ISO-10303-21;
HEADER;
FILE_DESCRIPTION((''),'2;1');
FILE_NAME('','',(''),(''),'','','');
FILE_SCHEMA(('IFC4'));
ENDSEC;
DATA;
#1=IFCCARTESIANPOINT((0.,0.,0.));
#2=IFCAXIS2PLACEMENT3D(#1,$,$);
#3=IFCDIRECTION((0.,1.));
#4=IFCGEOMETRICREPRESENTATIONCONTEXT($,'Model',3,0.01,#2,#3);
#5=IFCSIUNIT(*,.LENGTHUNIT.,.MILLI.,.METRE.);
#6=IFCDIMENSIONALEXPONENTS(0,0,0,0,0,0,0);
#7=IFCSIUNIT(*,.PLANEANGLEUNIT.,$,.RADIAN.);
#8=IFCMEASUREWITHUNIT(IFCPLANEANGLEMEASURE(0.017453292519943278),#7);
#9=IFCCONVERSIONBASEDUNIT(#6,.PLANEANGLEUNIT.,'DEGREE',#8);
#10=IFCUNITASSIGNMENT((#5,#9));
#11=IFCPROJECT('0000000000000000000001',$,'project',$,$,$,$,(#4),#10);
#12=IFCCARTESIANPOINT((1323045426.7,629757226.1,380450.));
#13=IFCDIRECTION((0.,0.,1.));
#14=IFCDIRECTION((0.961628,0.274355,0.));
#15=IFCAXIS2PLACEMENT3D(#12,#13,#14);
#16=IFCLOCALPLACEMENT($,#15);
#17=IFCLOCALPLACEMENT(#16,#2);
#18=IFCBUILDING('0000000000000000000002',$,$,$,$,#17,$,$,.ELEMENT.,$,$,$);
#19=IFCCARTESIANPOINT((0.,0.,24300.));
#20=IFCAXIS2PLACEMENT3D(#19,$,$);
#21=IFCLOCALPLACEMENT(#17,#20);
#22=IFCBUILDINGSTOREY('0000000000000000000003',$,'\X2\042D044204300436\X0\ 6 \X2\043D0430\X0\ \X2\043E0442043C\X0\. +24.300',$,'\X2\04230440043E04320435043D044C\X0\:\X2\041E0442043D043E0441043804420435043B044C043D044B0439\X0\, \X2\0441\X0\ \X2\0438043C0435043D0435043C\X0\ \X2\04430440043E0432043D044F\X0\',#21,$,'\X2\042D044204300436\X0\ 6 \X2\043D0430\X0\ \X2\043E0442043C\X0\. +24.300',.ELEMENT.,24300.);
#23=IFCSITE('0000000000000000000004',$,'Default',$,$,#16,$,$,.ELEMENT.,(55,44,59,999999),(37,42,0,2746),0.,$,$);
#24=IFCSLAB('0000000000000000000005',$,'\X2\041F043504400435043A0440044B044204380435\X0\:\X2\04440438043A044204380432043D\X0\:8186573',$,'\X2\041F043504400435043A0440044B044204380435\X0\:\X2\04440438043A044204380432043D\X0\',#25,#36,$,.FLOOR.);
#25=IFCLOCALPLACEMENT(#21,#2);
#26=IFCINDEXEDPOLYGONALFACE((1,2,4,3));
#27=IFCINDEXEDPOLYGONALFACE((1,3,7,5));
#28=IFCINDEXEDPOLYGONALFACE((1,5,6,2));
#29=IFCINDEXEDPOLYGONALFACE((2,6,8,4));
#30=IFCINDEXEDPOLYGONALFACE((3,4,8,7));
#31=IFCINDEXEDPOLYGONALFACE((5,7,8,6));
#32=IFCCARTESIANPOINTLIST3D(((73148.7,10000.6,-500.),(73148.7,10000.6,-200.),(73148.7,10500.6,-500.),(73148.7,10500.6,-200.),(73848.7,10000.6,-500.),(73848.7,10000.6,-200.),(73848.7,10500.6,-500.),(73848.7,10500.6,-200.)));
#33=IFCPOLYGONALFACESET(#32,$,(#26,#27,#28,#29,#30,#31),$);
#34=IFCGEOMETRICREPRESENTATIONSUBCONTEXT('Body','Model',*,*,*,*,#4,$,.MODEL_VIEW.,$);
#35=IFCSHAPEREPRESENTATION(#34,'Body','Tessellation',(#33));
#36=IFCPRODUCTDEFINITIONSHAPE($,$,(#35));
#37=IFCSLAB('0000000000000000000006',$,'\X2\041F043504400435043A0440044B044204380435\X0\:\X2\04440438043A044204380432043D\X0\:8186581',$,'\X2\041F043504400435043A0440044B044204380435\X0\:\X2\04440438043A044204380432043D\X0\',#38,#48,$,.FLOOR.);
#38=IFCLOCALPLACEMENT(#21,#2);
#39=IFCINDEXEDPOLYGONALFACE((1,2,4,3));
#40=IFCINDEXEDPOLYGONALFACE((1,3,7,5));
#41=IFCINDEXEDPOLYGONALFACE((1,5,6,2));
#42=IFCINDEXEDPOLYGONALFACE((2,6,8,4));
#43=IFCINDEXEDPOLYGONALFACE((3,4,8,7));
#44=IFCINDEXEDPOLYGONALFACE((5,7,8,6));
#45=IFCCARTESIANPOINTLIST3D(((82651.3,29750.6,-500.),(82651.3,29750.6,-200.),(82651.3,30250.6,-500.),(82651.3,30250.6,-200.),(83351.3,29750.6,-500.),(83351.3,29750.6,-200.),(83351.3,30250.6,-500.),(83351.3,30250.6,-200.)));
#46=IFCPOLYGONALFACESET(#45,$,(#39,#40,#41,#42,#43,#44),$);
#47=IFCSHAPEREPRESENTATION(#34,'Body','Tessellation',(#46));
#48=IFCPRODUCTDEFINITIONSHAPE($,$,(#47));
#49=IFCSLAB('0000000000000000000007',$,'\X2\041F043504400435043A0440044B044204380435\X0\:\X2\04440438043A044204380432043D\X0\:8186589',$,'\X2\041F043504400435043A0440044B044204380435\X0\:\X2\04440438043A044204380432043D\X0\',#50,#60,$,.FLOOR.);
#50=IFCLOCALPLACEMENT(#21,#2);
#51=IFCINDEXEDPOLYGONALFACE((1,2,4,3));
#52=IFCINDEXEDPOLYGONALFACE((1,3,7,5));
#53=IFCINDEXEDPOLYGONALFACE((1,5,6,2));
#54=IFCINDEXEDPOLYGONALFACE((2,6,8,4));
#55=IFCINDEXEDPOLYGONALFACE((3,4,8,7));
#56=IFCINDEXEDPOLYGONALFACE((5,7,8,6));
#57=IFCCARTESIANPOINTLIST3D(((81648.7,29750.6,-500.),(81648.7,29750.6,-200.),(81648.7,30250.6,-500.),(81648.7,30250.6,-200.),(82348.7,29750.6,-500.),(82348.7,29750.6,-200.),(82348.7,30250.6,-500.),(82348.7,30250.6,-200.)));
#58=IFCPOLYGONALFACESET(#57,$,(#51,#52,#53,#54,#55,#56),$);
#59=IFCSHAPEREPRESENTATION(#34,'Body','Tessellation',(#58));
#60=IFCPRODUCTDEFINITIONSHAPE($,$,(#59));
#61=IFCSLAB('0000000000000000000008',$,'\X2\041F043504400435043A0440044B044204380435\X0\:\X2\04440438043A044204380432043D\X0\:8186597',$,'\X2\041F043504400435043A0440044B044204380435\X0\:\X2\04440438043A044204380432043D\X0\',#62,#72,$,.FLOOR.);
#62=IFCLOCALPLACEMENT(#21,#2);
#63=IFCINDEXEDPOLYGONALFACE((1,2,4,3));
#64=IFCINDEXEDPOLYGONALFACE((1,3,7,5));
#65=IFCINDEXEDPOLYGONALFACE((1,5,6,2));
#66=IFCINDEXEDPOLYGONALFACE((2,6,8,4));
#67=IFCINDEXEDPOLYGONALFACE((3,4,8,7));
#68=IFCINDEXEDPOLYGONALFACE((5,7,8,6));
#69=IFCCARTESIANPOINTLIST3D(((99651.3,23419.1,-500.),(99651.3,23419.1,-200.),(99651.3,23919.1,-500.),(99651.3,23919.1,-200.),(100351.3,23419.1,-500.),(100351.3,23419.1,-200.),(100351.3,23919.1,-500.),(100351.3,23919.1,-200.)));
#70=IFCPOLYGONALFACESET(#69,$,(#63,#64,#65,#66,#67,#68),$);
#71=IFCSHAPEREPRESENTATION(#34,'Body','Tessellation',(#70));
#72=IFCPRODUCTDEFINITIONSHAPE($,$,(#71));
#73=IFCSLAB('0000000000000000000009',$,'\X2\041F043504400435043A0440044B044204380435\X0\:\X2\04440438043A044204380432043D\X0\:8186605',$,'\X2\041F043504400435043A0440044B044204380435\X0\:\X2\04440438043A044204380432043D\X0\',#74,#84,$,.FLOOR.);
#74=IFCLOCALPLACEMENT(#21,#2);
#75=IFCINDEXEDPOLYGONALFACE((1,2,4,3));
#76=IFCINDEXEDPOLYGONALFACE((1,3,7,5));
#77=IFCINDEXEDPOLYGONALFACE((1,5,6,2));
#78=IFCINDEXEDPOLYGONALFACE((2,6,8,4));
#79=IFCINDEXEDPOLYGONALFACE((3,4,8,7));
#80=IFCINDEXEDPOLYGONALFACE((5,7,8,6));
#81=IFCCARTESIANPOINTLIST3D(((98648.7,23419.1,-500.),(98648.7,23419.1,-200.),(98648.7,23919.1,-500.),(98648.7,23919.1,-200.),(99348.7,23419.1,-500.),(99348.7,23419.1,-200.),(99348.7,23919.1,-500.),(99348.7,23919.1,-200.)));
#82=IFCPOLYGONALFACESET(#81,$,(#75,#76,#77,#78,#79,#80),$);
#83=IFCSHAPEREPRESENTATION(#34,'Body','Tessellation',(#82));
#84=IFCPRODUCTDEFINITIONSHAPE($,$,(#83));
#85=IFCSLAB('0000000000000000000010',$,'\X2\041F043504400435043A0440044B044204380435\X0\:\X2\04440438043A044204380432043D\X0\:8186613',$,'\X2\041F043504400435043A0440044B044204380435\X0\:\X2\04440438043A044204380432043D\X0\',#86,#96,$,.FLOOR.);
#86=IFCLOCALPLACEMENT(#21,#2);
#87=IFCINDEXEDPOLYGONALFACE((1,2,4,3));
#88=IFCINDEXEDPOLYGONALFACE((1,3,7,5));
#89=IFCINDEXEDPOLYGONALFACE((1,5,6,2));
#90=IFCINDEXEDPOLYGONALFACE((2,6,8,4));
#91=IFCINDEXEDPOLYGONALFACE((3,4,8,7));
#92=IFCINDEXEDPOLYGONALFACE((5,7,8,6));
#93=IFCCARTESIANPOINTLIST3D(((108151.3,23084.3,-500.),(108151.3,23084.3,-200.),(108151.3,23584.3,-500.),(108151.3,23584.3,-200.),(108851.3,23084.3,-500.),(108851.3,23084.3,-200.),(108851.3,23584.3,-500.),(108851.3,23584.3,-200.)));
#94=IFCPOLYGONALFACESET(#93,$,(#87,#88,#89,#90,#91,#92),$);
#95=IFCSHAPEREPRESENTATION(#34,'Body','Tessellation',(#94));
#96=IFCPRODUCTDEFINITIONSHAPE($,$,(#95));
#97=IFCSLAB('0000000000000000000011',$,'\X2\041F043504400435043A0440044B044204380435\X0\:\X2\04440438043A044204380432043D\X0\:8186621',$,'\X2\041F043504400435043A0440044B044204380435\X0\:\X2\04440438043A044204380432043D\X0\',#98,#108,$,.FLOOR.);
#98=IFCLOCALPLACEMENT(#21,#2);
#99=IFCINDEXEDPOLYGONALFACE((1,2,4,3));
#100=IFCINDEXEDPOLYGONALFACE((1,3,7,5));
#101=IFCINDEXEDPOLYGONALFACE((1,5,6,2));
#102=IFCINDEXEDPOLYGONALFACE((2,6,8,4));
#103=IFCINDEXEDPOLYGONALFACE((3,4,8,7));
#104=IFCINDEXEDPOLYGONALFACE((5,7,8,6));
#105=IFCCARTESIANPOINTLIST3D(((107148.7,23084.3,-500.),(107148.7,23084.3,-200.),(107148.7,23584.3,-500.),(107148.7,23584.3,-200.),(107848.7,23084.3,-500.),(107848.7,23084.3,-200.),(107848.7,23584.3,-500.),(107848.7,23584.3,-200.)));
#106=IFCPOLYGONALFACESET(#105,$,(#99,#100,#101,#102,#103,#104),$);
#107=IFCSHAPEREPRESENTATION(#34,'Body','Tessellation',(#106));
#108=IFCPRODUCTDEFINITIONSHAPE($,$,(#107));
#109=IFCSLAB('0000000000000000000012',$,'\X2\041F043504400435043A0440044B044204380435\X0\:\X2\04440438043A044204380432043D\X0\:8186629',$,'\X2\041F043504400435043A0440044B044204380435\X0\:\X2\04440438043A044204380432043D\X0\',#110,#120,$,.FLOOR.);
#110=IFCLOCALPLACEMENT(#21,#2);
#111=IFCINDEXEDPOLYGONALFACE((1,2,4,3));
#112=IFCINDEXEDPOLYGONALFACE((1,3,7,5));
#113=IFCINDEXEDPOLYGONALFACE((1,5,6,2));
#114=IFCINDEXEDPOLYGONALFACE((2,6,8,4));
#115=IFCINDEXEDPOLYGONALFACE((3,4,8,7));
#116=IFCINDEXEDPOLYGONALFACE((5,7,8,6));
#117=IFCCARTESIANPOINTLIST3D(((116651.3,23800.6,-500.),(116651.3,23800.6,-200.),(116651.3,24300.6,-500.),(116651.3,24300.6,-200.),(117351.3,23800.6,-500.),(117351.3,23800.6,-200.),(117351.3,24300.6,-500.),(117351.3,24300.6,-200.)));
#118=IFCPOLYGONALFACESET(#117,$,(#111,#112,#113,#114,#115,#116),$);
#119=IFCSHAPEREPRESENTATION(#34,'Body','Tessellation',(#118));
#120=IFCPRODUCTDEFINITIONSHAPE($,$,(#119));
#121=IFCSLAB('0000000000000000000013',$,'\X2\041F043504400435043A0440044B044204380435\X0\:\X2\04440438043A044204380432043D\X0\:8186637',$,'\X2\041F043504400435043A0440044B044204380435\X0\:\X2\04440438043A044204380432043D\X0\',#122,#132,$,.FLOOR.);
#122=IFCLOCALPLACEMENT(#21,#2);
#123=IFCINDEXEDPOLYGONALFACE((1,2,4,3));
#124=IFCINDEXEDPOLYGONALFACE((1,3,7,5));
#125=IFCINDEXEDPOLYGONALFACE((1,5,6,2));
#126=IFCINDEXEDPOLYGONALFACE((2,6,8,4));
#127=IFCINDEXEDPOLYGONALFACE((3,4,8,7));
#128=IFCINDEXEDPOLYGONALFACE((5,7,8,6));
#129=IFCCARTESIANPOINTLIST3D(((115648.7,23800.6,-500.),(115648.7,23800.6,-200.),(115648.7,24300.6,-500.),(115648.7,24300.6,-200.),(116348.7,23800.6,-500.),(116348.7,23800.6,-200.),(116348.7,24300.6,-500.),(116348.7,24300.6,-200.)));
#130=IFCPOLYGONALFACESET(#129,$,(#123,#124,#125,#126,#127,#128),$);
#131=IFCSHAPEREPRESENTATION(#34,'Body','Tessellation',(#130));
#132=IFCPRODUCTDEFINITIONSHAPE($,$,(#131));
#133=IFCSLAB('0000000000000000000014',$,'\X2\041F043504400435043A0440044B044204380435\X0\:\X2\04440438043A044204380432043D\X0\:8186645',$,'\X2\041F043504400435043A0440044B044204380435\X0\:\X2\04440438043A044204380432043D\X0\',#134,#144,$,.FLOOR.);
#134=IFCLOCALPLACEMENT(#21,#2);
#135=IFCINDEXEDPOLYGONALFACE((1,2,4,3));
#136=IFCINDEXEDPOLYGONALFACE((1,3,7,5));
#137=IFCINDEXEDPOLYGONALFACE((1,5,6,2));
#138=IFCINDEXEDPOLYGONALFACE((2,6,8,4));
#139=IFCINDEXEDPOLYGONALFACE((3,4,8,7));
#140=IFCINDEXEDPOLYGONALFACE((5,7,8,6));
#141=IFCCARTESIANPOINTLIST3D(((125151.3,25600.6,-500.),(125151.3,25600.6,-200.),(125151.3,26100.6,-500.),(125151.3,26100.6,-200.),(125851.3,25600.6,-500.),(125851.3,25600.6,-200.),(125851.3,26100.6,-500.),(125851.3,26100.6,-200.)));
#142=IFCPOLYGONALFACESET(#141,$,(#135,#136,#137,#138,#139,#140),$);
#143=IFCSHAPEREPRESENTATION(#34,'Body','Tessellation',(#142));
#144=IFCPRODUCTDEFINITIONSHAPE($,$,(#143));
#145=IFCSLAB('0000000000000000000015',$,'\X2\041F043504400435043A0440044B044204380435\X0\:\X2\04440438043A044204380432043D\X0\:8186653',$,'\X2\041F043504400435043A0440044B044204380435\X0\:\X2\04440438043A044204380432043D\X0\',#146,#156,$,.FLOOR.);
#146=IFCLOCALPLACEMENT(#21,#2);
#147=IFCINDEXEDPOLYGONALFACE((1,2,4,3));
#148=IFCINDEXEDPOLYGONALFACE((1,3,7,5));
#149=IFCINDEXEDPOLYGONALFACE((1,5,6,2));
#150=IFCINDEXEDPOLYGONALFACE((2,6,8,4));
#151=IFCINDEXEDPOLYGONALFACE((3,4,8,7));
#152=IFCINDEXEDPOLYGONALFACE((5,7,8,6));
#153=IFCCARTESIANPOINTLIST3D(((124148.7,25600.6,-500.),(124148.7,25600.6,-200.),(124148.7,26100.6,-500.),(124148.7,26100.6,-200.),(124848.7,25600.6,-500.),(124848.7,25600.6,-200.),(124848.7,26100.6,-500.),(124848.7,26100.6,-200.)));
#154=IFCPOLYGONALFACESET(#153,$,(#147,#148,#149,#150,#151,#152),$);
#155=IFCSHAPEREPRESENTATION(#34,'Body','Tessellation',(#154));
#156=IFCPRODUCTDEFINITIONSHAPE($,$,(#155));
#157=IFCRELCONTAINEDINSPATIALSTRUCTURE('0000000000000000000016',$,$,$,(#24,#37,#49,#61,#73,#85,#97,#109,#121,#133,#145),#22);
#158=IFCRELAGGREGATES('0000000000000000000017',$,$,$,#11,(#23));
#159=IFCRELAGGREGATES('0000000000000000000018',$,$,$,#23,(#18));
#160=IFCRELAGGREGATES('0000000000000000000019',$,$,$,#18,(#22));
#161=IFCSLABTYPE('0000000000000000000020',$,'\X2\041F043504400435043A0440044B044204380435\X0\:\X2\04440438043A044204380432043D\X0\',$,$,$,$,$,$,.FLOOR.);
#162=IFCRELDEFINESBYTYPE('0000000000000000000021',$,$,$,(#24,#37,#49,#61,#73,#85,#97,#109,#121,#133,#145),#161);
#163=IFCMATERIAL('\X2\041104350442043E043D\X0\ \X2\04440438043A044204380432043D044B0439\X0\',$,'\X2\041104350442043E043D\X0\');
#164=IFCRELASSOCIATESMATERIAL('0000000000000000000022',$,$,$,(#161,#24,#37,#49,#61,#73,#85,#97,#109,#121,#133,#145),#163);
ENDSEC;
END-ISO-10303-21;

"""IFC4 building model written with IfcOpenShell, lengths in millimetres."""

from ifc_helpers import new_model, entity, si_unit, converted_unit, direction, frame, origin, place, context, subcontext, project, spatial, indexed_curve, outline, extrude, material, type_object, element, save


model = new_model("IFC4")

# Units and contexts
model_context = context("Model", 3, precision=0.01, world=origin(), true_north=direction((0.0, 1.0)))
body_context = subcontext(model_context, "Body", "Model", "MODEL_VIEW")
ifc_project = project(units=[si_unit("LENGTHUNIT", "METRE", prefix="MILLI"), converted_unit("PLANEANGLEUNIT", "DEGREE", entity("IfcPlaneAngleMeasure", 0.017453292519943278), si_unit("PLANEANGLEUNIT", "RADIAN"), dimensions=[0, 0, 0, 0, 0, 0, 0])], contexts=[model_context])

# Site, building, storey
site_placement = place(None, frame((1323045426.7, 629757226.1, 380450.0), z_axis=(0.0, 0.0, 1.0), x_axis=(0.961628, 0.274355, 0.0)))
site = spatial("IfcSite", under=ifc_project, at=site_placement, Name="Default", CompositionType="ELEMENT", RefLatitude=(55, 44, 59, 999999), RefLongitude=(37, 42, 0, 2746), RefElevation=0.0)
building_placement = place(site_placement, origin())
building = spatial("IfcBuilding", under=site, at=building_placement, CompositionType="ELEMENT")
storey_placement = place(building_placement, frame((0.0, 0.0, 24300.0)))
storey = spatial("IfcBuildingStorey", under=building, at=storey_placement, Name="Этаж 6 на отм. +24.300", ObjectType="Уровень:Относительный, с именем уровня", LongName="Этаж 6 на отм. +24.300", CompositionType="ELEMENT", Elevation=24300.0)

# Slabs
ifc_material_1 = material(Name="Бетон фиктивный", Category="Бетон")
slab_type_1 = type_object("IfcSlabType", Name="Перекрытие:фиктивн", PredefinedType="FLOOR", material=ifc_material_1)
slab_1_placement = place(storey_placement, origin())
element("IfcSlab", 1, at=slab_1_placement, inside=storey, type_object=slab_type_1, material=ifc_material_1, Name="Перекрытие:фиктивн:8186573", ObjectType="Перекрытие:фиктивн", PredefinedType="FLOOR", context=body_context, shape_type="SweptSolid", body=[
    extrude(outline(indexed_curve([(-250.0, -350.0), (250.0, -350.0), (250.0, 350.0), (-250.0, 350.0), (-250.0, -350.0)], self_intersect=False)), frame((73498.7, 10250.6, -200.0), z_axis=(0.0, 0.0, -1.0), x_axis=(0.0, 1.0, 0.0)), (0.0, 0.0, 1.0), 300.0),
])
slab_2_placement = place(storey_placement, origin())
element("IfcSlab", 2, at=slab_2_placement, inside=storey, type_object=slab_type_1, material=ifc_material_1, Name="Перекрытие:фиктивн:8186581", ObjectType="Перекрытие:фиктивн", PredefinedType="FLOOR", context=body_context, shape_type="SweptSolid", body=[
    extrude(outline(indexed_curve([(-250.0, -350.0), (250.0, -350.0), (250.0, 350.0), (-250.0, 350.0), (-250.0, -350.0)], self_intersect=False)), frame((83001.3, 30000.6, -200.0), z_axis=(0.0, 0.0, -1.0), x_axis=(0.0, 1.0, 0.0)), (0.0, 0.0, 1.0), 300.0),
])
slab_3_placement = place(storey_placement, origin())
element("IfcSlab", 3, at=slab_3_placement, inside=storey, type_object=slab_type_1, material=ifc_material_1, Name="Перекрытие:фиктивн:8186589", ObjectType="Перекрытие:фиктивн", PredefinedType="FLOOR", context=body_context, shape_type="SweptSolid", body=[
    extrude(outline(indexed_curve([(-250.0, -350.0), (250.0, -350.0), (250.0, 350.0), (-250.0, 350.0), (-250.0, -350.0)], self_intersect=False)), frame((81998.7, 30000.6, -200.0), z_axis=(0.0, 0.0, -1.0), x_axis=(0.0, 1.0, 0.0)), (0.0, 0.0, 1.0), 300.0),
])
slab_4_placement = place(storey_placement, origin())
element("IfcSlab", 4, at=slab_4_placement, inside=storey, type_object=slab_type_1, material=ifc_material_1, Name="Перекрытие:фиктивн:8186597", ObjectType="Перекрытие:фиктивн", PredefinedType="FLOOR", context=body_context, shape_type="SweptSolid", body=[
    extrude(outline(indexed_curve([(-250.0, -350.0), (250.0, -350.0), (250.0, 350.0), (-250.0, 350.0), (-250.0, -350.0)], self_intersect=False)), frame((100001.3, 23669.1, -200.0), z_axis=(0.0, 0.0, -1.0), x_axis=(0.0, 1.0, 0.0)), (0.0, 0.0, 1.0), 300.0),
])
slab_5_placement = place(storey_placement, origin())
element("IfcSlab", 5, at=slab_5_placement, inside=storey, type_object=slab_type_1, material=ifc_material_1, Name="Перекрытие:фиктивн:8186605", ObjectType="Перекрытие:фиктивн", PredefinedType="FLOOR", context=body_context, shape_type="SweptSolid", body=[
    extrude(outline(indexed_curve([(-250.0, -350.0), (250.0, -350.0), (250.0, 350.0), (-250.0, 350.0), (-250.0, -350.0)], self_intersect=False)), frame((98998.7, 23669.1, -200.0), z_axis=(0.0, 0.0, -1.0), x_axis=(0.0, 1.0, 0.0)), (0.0, 0.0, 1.0), 300.0),
])
slab_6_placement = place(storey_placement, origin())
element("IfcSlab", 6, at=slab_6_placement, inside=storey, type_object=slab_type_1, material=ifc_material_1, Name="Перекрытие:фиктивн:8186613", ObjectType="Перекрытие:фиктивн", PredefinedType="FLOOR", context=body_context, shape_type="SweptSolid", body=[
    extrude(outline(indexed_curve([(-250.0, -350.0), (250.0, -350.0), (250.0, 350.0), (-250.0, 350.0), (-250.0, -350.0)], self_intersect=False)), frame((108501.3, 23334.3, -200.0), z_axis=(0.0, 0.0, -1.0), x_axis=(0.0, 1.0, 0.0)), (0.0, 0.0, 1.0), 300.0),
])
slab_7_placement = place(storey_placement, origin())
element("IfcSlab", 7, at=slab_7_placement, inside=storey, type_object=slab_type_1, material=ifc_material_1, Name="Перекрытие:фиктивн:8186621", ObjectType="Перекрытие:фиктивн", PredefinedType="FLOOR", context=body_context, shape_type="SweptSolid", body=[
    extrude(outline(indexed_curve([(-250.0, -350.0), (250.0, -350.0), (250.0, 350.0), (-250.0, 350.0), (-250.0, -350.0)], self_intersect=False)), frame((107498.7, 23334.3, -200.0), z_axis=(0.0, 0.0, -1.0), x_axis=(0.0, 1.0, 0.0)), (0.0, 0.0, 1.0), 300.0),
])
slab_8_placement = place(storey_placement, origin())
element("IfcSlab", 8, at=slab_8_placement, inside=storey, type_object=slab_type_1, material=ifc_material_1, Name="Перекрытие:фиктивн:8186629", ObjectType="Перекрытие:фиктивн", PredefinedType="FLOOR", context=body_context, shape_type="SweptSolid", body=[
    extrude(outline(indexed_curve([(-250.0, -350.0), (250.0, -350.0), (250.0, 350.0), (-250.0, 350.0), (-250.0, -350.0)], self_intersect=False)), frame((117001.3, 24050.6, -200.0), z_axis=(0.0, 0.0, -1.0), x_axis=(0.0, 1.0, 0.0)), (0.0, 0.0, 1.0), 300.0),
])
slab_9_placement = place(storey_placement, origin())
element("IfcSlab", 9, at=slab_9_placement, inside=storey, type_object=slab_type_1, material=ifc_material_1, Name="Перекрытие:фиктивн:8186637", ObjectType="Перекрытие:фиктивн", PredefinedType="FLOOR", context=body_context, shape_type="SweptSolid", body=[
    extrude(outline(indexed_curve([(-250.0, -350.0), (250.0, -350.0), (250.0, 350.0), (-250.0, 350.0), (-250.0, -350.0)], self_intersect=False)), frame((115998.7, 24050.6, -200.0), z_axis=(0.0, 0.0, -1.0), x_axis=(0.0, 1.0, 0.0)), (0.0, 0.0, 1.0), 300.0),
])
slab_10_placement = place(storey_placement, origin())
element("IfcSlab", 10, at=slab_10_placement, inside=storey, type_object=slab_type_1, material=ifc_material_1, Name="Перекрытие:фиктивн:8186645", ObjectType="Перекрытие:фиктивн", PredefinedType="FLOOR", context=body_context, shape_type="SweptSolid", body=[
    extrude(outline(indexed_curve([(-250.0, -350.0), (250.0, -350.0), (250.0, 350.0), (-250.0, 350.0), (-250.0, -350.0)], self_intersect=False)), frame((125501.3, 25850.6, -200.0), z_axis=(0.0, 0.0, -1.0), x_axis=(0.0, 1.0, 0.0)), (0.0, 0.0, 1.0), 300.0),
])
slab_11_placement = place(storey_placement, origin())
element("IfcSlab", 11, at=slab_11_placement, inside=storey, type_object=slab_type_1, material=ifc_material_1, Name="Перекрытие:фиктивн:8186653", ObjectType="Перекрытие:фиктивн", PredefinedType="FLOOR", context=body_context, shape_type="SweptSolid", body=[
    extrude(outline(indexed_curve([(-250.0, -350.0), (250.0, -350.0), (250.0, 350.0), (-250.0, 350.0), (-250.0, -350.0)], self_intersect=False)), frame((124498.7, 25850.6, -200.0), z_axis=(0.0, 0.0, -1.0), x_axis=(0.0, 1.0, 0.0)), (0.0, 0.0, 1.0), 300.0),
])

save(model, "model.ifc")
